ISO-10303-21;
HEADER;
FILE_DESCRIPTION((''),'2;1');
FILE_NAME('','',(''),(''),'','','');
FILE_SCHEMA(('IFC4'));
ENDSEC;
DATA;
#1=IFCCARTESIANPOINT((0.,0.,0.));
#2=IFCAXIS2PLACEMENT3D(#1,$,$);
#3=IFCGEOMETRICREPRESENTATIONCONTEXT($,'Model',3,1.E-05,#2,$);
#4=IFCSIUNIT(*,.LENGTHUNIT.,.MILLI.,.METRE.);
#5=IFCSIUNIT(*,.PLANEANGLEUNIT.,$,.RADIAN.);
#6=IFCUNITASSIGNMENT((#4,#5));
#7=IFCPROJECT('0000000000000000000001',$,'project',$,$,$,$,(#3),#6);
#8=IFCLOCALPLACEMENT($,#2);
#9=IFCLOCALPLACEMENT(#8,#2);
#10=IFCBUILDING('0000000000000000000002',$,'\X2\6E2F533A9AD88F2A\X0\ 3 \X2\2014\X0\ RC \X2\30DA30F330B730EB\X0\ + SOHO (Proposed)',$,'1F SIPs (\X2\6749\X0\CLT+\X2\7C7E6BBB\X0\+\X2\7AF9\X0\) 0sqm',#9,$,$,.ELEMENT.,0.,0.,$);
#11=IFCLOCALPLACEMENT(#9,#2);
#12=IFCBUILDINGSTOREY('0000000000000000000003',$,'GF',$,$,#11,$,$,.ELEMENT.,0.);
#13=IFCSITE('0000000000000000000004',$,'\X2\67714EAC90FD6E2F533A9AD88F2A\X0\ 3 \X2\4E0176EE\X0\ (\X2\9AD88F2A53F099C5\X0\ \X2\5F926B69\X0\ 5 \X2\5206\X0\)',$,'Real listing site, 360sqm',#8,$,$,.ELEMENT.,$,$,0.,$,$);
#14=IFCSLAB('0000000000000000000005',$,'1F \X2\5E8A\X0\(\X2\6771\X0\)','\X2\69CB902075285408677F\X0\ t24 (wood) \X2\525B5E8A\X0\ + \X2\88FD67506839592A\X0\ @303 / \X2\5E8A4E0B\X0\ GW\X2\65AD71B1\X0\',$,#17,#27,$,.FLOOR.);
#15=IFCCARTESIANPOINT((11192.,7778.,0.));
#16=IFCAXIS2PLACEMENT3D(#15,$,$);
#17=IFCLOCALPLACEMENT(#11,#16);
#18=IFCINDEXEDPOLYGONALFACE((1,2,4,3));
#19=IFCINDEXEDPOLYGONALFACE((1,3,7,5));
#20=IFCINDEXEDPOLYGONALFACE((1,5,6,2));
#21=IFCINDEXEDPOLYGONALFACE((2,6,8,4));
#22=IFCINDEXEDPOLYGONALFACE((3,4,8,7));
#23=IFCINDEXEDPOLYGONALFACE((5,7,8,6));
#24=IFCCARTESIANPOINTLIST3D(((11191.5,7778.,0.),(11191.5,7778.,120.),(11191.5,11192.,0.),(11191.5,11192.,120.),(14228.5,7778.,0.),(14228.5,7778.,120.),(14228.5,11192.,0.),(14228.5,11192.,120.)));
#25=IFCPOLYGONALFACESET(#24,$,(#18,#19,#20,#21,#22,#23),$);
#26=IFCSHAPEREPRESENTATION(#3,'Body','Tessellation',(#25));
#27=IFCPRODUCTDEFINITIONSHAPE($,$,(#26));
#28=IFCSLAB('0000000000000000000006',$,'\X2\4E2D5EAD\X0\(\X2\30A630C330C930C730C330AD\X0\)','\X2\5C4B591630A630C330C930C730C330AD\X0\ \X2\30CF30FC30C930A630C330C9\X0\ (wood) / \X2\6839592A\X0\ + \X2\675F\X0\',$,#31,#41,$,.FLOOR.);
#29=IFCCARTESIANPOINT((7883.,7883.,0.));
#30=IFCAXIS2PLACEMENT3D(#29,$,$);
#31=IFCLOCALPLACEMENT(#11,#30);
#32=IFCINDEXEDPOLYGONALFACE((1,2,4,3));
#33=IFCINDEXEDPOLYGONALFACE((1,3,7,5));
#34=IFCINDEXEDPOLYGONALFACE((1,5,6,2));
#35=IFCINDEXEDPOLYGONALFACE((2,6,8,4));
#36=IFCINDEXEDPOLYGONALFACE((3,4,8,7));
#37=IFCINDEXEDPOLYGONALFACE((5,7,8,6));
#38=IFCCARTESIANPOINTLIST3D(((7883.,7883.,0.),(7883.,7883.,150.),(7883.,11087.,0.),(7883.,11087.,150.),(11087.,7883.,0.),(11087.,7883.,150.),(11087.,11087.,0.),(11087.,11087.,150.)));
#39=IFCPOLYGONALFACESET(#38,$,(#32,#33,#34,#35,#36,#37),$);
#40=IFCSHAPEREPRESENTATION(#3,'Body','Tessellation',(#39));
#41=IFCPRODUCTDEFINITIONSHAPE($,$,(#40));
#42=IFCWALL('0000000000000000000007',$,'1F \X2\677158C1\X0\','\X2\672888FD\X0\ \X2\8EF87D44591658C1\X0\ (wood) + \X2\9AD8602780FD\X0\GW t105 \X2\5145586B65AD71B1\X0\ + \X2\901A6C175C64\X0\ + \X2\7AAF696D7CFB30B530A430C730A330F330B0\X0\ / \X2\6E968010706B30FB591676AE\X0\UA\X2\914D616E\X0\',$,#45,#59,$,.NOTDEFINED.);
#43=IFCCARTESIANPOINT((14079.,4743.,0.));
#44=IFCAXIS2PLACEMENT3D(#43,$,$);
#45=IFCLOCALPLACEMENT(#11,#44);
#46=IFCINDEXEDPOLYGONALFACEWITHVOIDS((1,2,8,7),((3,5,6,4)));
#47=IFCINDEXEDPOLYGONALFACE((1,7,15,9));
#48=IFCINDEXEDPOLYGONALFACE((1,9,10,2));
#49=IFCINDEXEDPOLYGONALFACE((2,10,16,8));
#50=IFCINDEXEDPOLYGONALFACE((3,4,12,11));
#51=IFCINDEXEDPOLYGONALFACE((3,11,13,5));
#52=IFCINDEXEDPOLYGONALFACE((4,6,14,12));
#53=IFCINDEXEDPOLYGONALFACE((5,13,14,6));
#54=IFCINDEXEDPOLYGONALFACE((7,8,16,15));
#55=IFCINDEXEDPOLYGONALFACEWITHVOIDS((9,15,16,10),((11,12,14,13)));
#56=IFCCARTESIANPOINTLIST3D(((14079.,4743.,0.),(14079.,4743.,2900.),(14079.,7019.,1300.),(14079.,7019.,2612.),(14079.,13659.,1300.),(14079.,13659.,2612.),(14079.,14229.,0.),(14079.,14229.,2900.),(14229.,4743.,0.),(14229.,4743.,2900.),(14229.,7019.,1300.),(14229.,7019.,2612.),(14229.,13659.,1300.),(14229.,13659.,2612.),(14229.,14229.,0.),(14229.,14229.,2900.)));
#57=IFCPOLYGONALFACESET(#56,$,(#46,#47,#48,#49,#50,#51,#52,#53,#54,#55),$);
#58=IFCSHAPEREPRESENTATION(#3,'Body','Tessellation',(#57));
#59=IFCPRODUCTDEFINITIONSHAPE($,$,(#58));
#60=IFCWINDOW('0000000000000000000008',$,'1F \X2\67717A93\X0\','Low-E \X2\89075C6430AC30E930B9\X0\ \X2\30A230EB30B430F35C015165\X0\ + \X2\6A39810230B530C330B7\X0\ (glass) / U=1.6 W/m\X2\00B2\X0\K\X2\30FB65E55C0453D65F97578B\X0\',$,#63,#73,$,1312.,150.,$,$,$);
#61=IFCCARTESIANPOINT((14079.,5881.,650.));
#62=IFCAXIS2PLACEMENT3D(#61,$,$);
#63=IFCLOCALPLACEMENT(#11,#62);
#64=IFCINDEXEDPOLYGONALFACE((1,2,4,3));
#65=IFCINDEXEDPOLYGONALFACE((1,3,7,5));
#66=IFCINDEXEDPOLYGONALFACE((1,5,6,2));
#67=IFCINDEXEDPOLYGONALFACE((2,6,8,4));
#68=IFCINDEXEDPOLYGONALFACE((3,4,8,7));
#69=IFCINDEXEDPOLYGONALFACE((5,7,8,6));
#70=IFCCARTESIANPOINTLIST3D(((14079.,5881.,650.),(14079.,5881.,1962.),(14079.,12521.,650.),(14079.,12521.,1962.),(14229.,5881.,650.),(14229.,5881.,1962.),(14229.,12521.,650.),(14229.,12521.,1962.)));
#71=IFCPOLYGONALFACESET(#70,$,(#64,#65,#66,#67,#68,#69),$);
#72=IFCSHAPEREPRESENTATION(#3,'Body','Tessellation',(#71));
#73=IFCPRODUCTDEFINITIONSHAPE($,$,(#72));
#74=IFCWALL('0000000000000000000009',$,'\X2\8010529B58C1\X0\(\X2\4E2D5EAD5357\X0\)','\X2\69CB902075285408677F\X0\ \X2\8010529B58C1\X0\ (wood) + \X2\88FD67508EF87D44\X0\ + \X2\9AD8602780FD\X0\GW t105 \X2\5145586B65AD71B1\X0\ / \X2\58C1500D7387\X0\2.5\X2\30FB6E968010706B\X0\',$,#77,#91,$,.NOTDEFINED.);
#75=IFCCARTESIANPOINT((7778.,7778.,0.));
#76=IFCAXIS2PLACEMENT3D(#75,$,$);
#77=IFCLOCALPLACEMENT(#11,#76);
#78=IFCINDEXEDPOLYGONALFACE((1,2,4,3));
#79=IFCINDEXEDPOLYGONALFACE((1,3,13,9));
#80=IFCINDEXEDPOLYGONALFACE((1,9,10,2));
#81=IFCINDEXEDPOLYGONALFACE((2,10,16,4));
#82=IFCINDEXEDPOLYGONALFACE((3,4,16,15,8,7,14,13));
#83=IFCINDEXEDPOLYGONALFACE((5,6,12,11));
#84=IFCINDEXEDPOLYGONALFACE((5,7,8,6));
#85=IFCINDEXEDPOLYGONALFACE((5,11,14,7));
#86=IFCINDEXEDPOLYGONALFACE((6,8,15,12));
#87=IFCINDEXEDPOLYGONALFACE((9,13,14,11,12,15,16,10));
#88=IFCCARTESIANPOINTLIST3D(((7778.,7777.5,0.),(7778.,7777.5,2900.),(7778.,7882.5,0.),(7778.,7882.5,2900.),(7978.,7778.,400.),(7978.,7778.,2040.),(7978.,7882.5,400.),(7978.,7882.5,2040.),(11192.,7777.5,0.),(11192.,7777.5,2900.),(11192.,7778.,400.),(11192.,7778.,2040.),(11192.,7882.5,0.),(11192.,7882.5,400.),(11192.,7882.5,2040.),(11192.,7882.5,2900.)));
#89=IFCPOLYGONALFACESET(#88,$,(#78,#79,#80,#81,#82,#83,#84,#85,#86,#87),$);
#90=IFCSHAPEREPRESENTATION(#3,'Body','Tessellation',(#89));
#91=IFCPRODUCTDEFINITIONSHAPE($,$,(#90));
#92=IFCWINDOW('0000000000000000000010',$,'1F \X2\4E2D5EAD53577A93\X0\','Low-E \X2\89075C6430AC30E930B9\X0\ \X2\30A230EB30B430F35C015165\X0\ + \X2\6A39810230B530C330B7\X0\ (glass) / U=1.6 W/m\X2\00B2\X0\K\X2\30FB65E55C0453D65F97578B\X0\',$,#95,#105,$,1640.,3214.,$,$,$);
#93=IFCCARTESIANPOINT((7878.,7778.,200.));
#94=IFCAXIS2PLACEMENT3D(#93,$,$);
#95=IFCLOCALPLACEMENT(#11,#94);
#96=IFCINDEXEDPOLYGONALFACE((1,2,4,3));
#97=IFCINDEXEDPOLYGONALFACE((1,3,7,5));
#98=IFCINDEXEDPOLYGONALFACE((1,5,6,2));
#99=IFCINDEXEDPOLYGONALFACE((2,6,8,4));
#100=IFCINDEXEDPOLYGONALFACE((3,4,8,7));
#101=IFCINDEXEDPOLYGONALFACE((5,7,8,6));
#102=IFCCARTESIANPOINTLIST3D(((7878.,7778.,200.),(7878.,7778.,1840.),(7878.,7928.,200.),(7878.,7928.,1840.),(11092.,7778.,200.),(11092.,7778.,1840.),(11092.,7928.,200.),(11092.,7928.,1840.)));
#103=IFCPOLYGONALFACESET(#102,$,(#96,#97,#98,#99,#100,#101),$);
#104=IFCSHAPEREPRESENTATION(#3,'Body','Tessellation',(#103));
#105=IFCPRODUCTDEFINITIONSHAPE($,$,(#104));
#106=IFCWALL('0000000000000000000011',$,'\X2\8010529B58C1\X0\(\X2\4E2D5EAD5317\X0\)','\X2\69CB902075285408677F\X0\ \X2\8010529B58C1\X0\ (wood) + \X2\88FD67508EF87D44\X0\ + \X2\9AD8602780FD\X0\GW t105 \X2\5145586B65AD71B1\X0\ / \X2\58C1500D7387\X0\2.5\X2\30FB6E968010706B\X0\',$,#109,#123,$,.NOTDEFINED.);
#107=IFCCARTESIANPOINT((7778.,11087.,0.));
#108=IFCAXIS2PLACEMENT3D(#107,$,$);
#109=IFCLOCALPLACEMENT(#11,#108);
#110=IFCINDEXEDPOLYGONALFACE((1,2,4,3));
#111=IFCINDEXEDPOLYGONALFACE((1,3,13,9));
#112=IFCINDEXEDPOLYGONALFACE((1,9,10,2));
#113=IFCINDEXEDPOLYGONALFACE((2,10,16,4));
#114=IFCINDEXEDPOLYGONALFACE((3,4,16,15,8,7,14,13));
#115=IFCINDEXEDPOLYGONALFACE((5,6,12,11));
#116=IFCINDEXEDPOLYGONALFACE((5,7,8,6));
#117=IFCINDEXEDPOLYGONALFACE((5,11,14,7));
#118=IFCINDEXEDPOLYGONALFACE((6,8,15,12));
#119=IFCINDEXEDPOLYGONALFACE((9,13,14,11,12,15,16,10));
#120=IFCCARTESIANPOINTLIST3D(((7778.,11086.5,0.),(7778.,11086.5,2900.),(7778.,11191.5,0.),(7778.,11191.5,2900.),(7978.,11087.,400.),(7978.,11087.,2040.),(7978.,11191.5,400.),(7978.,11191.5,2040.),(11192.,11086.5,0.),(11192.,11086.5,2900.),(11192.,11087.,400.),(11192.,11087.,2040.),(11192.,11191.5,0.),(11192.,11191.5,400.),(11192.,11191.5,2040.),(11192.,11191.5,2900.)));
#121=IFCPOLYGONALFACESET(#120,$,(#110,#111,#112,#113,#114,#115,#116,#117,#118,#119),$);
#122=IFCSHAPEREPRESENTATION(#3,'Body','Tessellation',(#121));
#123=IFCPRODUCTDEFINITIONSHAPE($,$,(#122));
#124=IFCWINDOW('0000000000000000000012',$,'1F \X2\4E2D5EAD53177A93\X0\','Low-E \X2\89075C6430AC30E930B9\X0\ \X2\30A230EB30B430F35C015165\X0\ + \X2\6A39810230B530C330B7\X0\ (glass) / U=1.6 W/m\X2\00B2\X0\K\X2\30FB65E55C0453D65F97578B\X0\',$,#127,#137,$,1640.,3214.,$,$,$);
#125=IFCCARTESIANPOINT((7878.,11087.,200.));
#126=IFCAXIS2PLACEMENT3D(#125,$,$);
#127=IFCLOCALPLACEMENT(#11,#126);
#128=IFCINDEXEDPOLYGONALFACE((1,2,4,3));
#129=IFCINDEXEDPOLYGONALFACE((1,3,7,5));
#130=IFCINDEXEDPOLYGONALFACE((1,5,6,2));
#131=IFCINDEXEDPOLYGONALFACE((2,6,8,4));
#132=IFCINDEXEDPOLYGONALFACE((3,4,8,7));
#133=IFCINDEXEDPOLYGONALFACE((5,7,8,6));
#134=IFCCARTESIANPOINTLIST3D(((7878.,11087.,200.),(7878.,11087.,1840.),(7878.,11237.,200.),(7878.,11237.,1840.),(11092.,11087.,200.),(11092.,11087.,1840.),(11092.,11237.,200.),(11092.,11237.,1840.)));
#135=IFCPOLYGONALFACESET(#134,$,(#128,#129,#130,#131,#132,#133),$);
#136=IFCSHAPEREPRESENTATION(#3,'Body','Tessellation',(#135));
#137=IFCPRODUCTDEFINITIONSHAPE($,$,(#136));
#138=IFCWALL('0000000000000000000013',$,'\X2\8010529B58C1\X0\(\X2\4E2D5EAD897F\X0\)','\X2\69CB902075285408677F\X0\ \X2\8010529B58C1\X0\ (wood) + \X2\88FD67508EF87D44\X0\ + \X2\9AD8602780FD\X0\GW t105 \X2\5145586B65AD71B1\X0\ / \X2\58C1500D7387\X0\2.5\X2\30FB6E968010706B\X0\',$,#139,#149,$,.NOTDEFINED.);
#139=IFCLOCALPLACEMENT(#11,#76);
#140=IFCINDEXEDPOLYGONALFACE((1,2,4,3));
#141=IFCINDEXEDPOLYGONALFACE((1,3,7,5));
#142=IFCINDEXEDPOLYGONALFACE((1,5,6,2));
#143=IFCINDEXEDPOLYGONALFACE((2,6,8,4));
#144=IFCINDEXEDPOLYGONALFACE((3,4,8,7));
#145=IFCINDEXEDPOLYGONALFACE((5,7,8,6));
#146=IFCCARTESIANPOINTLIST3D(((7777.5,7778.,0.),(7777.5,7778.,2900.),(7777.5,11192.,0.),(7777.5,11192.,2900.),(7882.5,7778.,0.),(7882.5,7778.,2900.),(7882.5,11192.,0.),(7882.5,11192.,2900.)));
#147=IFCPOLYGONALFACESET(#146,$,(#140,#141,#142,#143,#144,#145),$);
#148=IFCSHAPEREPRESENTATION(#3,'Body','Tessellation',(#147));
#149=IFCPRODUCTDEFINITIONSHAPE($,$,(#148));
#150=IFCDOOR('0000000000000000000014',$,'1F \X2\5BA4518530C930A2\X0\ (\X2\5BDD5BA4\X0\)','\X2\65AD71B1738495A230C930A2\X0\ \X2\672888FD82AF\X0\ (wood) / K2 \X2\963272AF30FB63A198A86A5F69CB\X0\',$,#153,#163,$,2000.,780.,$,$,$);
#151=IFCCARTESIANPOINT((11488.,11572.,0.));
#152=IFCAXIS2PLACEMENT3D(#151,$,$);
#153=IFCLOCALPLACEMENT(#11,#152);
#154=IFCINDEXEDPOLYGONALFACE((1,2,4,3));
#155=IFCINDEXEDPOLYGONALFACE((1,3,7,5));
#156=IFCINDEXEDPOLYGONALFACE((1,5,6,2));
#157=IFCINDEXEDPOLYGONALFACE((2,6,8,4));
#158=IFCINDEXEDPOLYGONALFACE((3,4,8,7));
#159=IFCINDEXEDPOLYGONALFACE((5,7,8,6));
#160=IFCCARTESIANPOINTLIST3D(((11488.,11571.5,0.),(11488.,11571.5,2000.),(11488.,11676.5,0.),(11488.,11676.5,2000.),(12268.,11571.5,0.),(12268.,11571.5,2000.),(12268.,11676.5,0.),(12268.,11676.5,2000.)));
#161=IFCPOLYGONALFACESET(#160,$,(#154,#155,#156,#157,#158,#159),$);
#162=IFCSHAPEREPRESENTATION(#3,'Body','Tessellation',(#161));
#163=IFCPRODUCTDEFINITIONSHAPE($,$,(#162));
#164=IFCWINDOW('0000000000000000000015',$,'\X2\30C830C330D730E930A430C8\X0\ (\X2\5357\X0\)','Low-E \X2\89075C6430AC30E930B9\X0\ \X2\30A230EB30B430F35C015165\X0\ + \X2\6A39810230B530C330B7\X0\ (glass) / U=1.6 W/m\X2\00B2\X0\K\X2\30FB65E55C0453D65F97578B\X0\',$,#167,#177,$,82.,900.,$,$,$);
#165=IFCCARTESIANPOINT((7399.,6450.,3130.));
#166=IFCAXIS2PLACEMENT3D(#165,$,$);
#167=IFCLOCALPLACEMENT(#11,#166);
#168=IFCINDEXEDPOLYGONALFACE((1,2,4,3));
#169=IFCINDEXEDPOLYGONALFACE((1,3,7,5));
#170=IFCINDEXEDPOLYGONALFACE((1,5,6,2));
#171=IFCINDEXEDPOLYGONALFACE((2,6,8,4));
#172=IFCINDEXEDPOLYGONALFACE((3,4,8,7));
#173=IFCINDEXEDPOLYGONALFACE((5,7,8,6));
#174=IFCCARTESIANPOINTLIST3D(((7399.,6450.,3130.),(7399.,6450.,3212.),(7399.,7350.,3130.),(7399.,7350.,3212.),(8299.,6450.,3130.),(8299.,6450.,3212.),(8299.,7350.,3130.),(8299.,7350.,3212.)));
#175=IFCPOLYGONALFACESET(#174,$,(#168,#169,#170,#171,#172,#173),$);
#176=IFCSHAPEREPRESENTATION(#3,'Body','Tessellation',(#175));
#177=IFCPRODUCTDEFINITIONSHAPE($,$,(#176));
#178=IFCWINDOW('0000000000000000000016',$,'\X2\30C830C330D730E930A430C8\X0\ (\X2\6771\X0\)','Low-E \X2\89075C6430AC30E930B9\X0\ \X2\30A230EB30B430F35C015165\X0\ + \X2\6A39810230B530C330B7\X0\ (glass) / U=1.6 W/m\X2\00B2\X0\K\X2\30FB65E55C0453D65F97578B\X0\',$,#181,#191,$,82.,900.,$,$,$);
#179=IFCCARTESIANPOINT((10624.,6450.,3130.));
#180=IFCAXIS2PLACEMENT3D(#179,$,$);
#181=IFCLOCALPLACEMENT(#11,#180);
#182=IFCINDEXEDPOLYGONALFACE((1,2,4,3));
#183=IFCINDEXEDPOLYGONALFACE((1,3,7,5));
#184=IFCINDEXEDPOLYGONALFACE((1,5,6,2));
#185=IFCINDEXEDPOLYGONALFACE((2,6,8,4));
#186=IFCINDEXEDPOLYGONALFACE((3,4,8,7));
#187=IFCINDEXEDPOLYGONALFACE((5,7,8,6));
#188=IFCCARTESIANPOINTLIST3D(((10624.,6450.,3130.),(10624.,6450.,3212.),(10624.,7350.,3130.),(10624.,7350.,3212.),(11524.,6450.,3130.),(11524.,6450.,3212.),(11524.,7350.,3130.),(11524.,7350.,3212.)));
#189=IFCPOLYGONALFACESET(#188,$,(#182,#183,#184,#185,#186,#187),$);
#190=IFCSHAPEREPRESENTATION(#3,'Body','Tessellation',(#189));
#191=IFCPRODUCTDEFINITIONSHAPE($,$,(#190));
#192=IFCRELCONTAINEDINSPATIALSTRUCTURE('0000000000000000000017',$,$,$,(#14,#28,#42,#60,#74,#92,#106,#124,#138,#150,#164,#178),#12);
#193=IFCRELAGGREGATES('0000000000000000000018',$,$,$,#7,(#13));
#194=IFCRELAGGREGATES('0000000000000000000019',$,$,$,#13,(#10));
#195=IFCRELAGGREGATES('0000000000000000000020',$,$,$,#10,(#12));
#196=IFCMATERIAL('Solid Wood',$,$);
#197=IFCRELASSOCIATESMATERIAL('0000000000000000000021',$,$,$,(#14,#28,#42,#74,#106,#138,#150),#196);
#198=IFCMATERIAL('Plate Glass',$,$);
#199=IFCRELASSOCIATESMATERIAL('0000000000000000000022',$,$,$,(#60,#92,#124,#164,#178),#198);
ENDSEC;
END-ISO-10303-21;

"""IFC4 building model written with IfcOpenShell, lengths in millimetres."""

from ifc_helpers import new_model, si_unit, frame, frame_2d, origin, place, context, project, spatial, rectangle, extrude, material, element, fill, save


model = new_model("IFC4")

# Units and contexts
model_context = context("Model", 3, precision=1e-05, world=origin())
ifc_project = project(units=[si_unit("LENGTHUNIT", "METRE", prefix="MILLI"), si_unit("PLANEANGLEUNIT", "RADIAN")], contexts=[model_context])

# Site, building, storey
site_placement = place(None, origin())
site = spatial("IfcSite", under=ifc_project, at=site_placement, Name="東京都港区高輪 3 丁目 (高輪台駅 徒歩 5 分)", ObjectType="Real listing site, 360sqm", CompositionType="ELEMENT", RefElevation=0.0)
building_placement = place(site_placement, origin())
building = spatial("IfcBuilding", under=site, at=building_placement, Name="港区高輪 3 — RC ペンシル + SOHO (Proposed)", ObjectType="1F SIPs (杉CLT+籾殻+竹) 0sqm", CompositionType="ELEMENT", ElevationOfRefHeight=0.0, ElevationOfTerrain=0.0)
storey_placement = place(building_placement, origin())
storey = spatial("IfcBuildingStorey", under=building, at=storey_placement, Name="GF", CompositionType="ELEMENT", Elevation=0.0)

# Slabs
ifc_material_1 = material(Name="Solid Wood")
slab_1_placement = place(storey_placement, frame((11192.0, 7778.0, 0.0)))
element("IfcSlab", 1, at=slab_1_placement, inside=storey, material=ifc_material_1, Name="1F 床(東)", Description="構造用合板 t24 (wood) 剛床 + 製材根太 @303 / 床下 GW断熱", PredefinedType="FLOOR", context=model_context, shape_type="SweptSolid", body=[
    extrude(rectangle(XDim=3037.0, YDim=3414.0, at=frame_2d((1518.0, 1707.0))), frame((11192.0, 7778.0, 0.0)), (0.0, 0.0, 1.0), 120.0),
])
slab_2_placement = place(storey_placement, frame((7883.0, 7883.0, 0.0)))
element("IfcSlab", 2, at=slab_2_placement, inside=storey, material=ifc_material_1, Name="中庭(ウッドデッキ)", Description="屋外ウッドデッキ ハードウッド (wood) / 根太 + 束", PredefinedType="FLOOR", context=model_context, shape_type="SweptSolid", body=[
    extrude(rectangle(XDim=3204.0, YDim=3204.0, at=frame_2d((1602.0, 1602.0))), frame((7883.0, 7883.0, 0.0)), (0.0, 0.0, 1.0), 150.0),
])

# Walls, openings, windows
wall_1_placement = place(storey_placement, frame((14079.0, 4743.0, 0.0)))
wall_1 = element("IfcWall", 3, at=wall_1_placement, inside=storey, material=ifc_material_1, Name="1F 東壁", Description="木製 軸組外壁 (wood) + 高性能GW t105 充填断熱 + 通気層 + 窯業系サイディング / 準耐火・外皮UA配慮", PredefinedType="NOTDEFINED", context=model_context, shape_type="SweptSolid", body=[
    extrude(rectangle(XDim=150.0, YDim=9486.0, at=frame_2d((75.0, 4743.0))), frame((14079.0, 4743.0, 0.0)), (0.0, 0.0, 1.0), 2900.0),
])
opening_1_placement = place(storey_placement, frame((14079.0, 5881.0, 650.0)))
opening_1 = element("IfcOpeningElement", 4, at=opening_1_placement, cuts=wall_1, PredefinedType="NOTDEFINED", context=model_context, shape_type="SweptSolid", body=[
    extrude(rectangle(XDim=150.0, YDim=6640.0, at=frame_2d((75.0, 3320.0))), frame((14079.0, 5881.0, 650.0)), (0.0, 0.0, 1.0), 1312.0),
])
ifc_material_2 = material(Name="Plate Glass")
window_1_placement = place(storey_placement, frame((14079.0, 5881.0, 650.0)))
window_1 = element("IfcWindow", 5, at=window_1_placement, inside=storey, material=ifc_material_2, Name="1F 東窓", Description="Low-E 複層ガラス アルゴン封入 + 樹脂サッシ (glass) / U=1.6 W/m²K・日射取得型", OverallHeight=1312.0, OverallWidth=150.0, context=model_context, shape_type="SweptSolid", body=[
    extrude(rectangle(XDim=150.0, YDim=6640.0, at=frame_2d((75.0, 3320.0))), frame((14079.0, 5881.0, 650.0)), (0.0, 0.0, 1.0), 1312.0),
])
fill(opening_1, window_1)
wall_2_placement = place(storey_placement, frame((7778.0, 7778.0, 0.0)))
wall_2 = element("IfcWall", 6, at=wall_2_placement, inside=storey, material=ifc_material_1, Name="耐力壁(中庭南)", Description="構造用合板 耐力壁 (wood) + 製材軸組 + 高性能GW t105 充填断熱 / 壁倍率2.5・準耐火", PredefinedType="NOTDEFINED", context=model_context, shape_type="SweptSolid", body=[
    extrude(rectangle(XDim=3414.0, YDim=105.0, at=frame_2d((1707.0, 52.0))), frame((7778.0, 7778.0, 0.0)), (0.0, 0.0, 1.0), 2900.0),
])
opening_2_placement = place(storey_placement, frame((7878.0, 7778.0, 200.0)))
opening_2 = element("IfcOpeningElement", 7, at=opening_2_placement, cuts=wall_2, PredefinedType="NOTDEFINED", context=model_context, shape_type="SweptSolid", body=[
    extrude(rectangle(XDim=3214.0, YDim=150.0, at=frame_2d((1607.0, 75.0))), frame((7878.0, 7778.0, 200.0)), (0.0, 0.0, 1.0), 1640.0),
])
window_2_placement = place(storey_placement, frame((7878.0, 7778.0, 200.0)))
window_2 = element("IfcWindow", 8, at=window_2_placement, inside=storey, material=ifc_material_2, Name="1F 中庭南窓", Description="Low-E 複層ガラス アルゴン封入 + 樹脂サッシ (glass) / U=1.6 W/m²K・日射取得型", OverallHeight=1640.0, OverallWidth=3214.0, context=model_context, shape_type="SweptSolid", body=[
    extrude(rectangle(XDim=3214.0, YDim=150.0, at=frame_2d((1607.0, 75.0))), frame((7878.0, 7778.0, 200.0)), (0.0, 0.0, 1.0), 1640.0),
])
fill(opening_2, window_2)
wall_3_placement = place(storey_placement, frame((7778.0, 11087.0, 0.0)))
wall_3 = element("IfcWall", 9, at=wall_3_placement, inside=storey, material=ifc_material_1, Name="耐力壁(中庭北)", Description="構造用合板 耐力壁 (wood) + 製材軸組 + 高性能GW t105 充填断熱 / 壁倍率2.5・準耐火", PredefinedType="NOTDEFINED", context=model_context, shape_type="SweptSolid", body=[
    extrude(rectangle(XDim=3414.0, YDim=105.0, at=frame_2d((1707.0, 52.0))), frame((7778.0, 11087.0, 0.0)), (0.0, 0.0, 1.0), 2900.0),
])
opening_3_placement = place(storey_placement, frame((7878.0, 11087.0, 200.0)))
opening_3 = element("IfcOpeningElement", 10, at=opening_3_placement, cuts=wall_3, PredefinedType="NOTDEFINED", context=model_context, shape_type="SweptSolid", body=[
    extrude(rectangle(XDim=3214.0, YDim=150.0, at=frame_2d((1607.0, 75.0))), frame((7878.0, 11087.0, 200.0)), (0.0, 0.0, 1.0), 1640.0),
])
window_3_placement = place(storey_placement, frame((7878.0, 11087.0, 200.0)))
window_3 = element("IfcWindow", 11, at=window_3_placement, inside=storey, material=ifc_material_2, Name="1F 中庭北窓", Description="Low-E 複層ガラス アルゴン封入 + 樹脂サッシ (glass) / U=1.6 W/m²K・日射取得型", OverallHeight=1640.0, OverallWidth=3214.0, context=model_context, shape_type="SweptSolid", body=[
    extrude(rectangle(XDim=3214.0, YDim=150.0, at=frame_2d((1607.0, 75.0))), frame((7878.0, 11087.0, 200.0)), (0.0, 0.0, 1.0), 1640.0),
])
fill(opening_3, window_3)

# Wall
wall_4_placement = place(storey_placement, frame((7778.0, 7778.0, 0.0)))
element("IfcWall", 12, at=wall_4_placement, inside=storey, material=ifc_material_1, Name="耐力壁(中庭西)", Description="構造用合板 耐力壁 (wood) + 製材軸組 + 高性能GW t105 充填断熱 / 壁倍率2.5・準耐火", PredefinedType="NOTDEFINED", context=model_context, shape_type="SweptSolid", body=[
    extrude(rectangle(XDim=105.0, YDim=3414.0, at=frame_2d((52.0, 1707.0))), frame((7778.0, 7778.0, 0.0)), (0.0, 0.0, 1.0), 2900.0),
])

# Door
door_placement = place(storey_placement, frame((11488.0, 11572.0, 0.0)))
element("IfcDoor", 13, at=door_placement, inside=storey, material=ifc_material_1, Name="1F 室内ドア (寝室)", Description="断熱玄関ドア 木製芯 (wood) / K2 防犯・採風機構", OverallHeight=2000.0, OverallWidth=780.0, context=model_context, shape_type="SweptSolid", body=[
    extrude(rectangle(XDim=780.0, YDim=105.0, at=frame_2d((390.0, 52.0))), frame((11488.0, 11572.0, 0.0)), (0.0, 0.0, 1.0), 2000.0),
])

# Windows
window_4_placement = place(storey_placement, frame((7399.0, 6450.0, 3130.0)))
element("IfcWindow", 14, at=window_4_placement, inside=storey, material=ifc_material_2, Name="トップライト (南)", Description="Low-E 複層ガラス アルゴン封入 + 樹脂サッシ (glass) / U=1.6 W/m²K・日射取得型", OverallHeight=82.0, OverallWidth=900.0, context=model_context, shape_type="SweptSolid", body=[
    extrude(rectangle(XDim=900.0, YDim=900.0, at=frame_2d((450.0, 450.0))), frame((7399.0, 6450.0, 3130.0)), (0.0, 0.0, 1.0), 82.0),
])
window_5_placement = place(storey_placement, frame((10624.0, 6450.0, 3130.0)))
element("IfcWindow", 15, at=window_5_placement, inside=storey, material=ifc_material_2, Name="トップライト (東)", Description="Low-E 複層ガラス アルゴン封入 + 樹脂サッシ (glass) / U=1.6 W/m²K・日射取得型", OverallHeight=82.0, OverallWidth=900.0, context=model_context, shape_type="SweptSolid", body=[
    extrude(rectangle(XDim=900.0, YDim=900.0, at=frame_2d((450.0, 450.0))), frame((10624.0, 6450.0, 3130.0)), (0.0, 0.0, 1.0), 82.0),
])

save(model, "model.ifc")
